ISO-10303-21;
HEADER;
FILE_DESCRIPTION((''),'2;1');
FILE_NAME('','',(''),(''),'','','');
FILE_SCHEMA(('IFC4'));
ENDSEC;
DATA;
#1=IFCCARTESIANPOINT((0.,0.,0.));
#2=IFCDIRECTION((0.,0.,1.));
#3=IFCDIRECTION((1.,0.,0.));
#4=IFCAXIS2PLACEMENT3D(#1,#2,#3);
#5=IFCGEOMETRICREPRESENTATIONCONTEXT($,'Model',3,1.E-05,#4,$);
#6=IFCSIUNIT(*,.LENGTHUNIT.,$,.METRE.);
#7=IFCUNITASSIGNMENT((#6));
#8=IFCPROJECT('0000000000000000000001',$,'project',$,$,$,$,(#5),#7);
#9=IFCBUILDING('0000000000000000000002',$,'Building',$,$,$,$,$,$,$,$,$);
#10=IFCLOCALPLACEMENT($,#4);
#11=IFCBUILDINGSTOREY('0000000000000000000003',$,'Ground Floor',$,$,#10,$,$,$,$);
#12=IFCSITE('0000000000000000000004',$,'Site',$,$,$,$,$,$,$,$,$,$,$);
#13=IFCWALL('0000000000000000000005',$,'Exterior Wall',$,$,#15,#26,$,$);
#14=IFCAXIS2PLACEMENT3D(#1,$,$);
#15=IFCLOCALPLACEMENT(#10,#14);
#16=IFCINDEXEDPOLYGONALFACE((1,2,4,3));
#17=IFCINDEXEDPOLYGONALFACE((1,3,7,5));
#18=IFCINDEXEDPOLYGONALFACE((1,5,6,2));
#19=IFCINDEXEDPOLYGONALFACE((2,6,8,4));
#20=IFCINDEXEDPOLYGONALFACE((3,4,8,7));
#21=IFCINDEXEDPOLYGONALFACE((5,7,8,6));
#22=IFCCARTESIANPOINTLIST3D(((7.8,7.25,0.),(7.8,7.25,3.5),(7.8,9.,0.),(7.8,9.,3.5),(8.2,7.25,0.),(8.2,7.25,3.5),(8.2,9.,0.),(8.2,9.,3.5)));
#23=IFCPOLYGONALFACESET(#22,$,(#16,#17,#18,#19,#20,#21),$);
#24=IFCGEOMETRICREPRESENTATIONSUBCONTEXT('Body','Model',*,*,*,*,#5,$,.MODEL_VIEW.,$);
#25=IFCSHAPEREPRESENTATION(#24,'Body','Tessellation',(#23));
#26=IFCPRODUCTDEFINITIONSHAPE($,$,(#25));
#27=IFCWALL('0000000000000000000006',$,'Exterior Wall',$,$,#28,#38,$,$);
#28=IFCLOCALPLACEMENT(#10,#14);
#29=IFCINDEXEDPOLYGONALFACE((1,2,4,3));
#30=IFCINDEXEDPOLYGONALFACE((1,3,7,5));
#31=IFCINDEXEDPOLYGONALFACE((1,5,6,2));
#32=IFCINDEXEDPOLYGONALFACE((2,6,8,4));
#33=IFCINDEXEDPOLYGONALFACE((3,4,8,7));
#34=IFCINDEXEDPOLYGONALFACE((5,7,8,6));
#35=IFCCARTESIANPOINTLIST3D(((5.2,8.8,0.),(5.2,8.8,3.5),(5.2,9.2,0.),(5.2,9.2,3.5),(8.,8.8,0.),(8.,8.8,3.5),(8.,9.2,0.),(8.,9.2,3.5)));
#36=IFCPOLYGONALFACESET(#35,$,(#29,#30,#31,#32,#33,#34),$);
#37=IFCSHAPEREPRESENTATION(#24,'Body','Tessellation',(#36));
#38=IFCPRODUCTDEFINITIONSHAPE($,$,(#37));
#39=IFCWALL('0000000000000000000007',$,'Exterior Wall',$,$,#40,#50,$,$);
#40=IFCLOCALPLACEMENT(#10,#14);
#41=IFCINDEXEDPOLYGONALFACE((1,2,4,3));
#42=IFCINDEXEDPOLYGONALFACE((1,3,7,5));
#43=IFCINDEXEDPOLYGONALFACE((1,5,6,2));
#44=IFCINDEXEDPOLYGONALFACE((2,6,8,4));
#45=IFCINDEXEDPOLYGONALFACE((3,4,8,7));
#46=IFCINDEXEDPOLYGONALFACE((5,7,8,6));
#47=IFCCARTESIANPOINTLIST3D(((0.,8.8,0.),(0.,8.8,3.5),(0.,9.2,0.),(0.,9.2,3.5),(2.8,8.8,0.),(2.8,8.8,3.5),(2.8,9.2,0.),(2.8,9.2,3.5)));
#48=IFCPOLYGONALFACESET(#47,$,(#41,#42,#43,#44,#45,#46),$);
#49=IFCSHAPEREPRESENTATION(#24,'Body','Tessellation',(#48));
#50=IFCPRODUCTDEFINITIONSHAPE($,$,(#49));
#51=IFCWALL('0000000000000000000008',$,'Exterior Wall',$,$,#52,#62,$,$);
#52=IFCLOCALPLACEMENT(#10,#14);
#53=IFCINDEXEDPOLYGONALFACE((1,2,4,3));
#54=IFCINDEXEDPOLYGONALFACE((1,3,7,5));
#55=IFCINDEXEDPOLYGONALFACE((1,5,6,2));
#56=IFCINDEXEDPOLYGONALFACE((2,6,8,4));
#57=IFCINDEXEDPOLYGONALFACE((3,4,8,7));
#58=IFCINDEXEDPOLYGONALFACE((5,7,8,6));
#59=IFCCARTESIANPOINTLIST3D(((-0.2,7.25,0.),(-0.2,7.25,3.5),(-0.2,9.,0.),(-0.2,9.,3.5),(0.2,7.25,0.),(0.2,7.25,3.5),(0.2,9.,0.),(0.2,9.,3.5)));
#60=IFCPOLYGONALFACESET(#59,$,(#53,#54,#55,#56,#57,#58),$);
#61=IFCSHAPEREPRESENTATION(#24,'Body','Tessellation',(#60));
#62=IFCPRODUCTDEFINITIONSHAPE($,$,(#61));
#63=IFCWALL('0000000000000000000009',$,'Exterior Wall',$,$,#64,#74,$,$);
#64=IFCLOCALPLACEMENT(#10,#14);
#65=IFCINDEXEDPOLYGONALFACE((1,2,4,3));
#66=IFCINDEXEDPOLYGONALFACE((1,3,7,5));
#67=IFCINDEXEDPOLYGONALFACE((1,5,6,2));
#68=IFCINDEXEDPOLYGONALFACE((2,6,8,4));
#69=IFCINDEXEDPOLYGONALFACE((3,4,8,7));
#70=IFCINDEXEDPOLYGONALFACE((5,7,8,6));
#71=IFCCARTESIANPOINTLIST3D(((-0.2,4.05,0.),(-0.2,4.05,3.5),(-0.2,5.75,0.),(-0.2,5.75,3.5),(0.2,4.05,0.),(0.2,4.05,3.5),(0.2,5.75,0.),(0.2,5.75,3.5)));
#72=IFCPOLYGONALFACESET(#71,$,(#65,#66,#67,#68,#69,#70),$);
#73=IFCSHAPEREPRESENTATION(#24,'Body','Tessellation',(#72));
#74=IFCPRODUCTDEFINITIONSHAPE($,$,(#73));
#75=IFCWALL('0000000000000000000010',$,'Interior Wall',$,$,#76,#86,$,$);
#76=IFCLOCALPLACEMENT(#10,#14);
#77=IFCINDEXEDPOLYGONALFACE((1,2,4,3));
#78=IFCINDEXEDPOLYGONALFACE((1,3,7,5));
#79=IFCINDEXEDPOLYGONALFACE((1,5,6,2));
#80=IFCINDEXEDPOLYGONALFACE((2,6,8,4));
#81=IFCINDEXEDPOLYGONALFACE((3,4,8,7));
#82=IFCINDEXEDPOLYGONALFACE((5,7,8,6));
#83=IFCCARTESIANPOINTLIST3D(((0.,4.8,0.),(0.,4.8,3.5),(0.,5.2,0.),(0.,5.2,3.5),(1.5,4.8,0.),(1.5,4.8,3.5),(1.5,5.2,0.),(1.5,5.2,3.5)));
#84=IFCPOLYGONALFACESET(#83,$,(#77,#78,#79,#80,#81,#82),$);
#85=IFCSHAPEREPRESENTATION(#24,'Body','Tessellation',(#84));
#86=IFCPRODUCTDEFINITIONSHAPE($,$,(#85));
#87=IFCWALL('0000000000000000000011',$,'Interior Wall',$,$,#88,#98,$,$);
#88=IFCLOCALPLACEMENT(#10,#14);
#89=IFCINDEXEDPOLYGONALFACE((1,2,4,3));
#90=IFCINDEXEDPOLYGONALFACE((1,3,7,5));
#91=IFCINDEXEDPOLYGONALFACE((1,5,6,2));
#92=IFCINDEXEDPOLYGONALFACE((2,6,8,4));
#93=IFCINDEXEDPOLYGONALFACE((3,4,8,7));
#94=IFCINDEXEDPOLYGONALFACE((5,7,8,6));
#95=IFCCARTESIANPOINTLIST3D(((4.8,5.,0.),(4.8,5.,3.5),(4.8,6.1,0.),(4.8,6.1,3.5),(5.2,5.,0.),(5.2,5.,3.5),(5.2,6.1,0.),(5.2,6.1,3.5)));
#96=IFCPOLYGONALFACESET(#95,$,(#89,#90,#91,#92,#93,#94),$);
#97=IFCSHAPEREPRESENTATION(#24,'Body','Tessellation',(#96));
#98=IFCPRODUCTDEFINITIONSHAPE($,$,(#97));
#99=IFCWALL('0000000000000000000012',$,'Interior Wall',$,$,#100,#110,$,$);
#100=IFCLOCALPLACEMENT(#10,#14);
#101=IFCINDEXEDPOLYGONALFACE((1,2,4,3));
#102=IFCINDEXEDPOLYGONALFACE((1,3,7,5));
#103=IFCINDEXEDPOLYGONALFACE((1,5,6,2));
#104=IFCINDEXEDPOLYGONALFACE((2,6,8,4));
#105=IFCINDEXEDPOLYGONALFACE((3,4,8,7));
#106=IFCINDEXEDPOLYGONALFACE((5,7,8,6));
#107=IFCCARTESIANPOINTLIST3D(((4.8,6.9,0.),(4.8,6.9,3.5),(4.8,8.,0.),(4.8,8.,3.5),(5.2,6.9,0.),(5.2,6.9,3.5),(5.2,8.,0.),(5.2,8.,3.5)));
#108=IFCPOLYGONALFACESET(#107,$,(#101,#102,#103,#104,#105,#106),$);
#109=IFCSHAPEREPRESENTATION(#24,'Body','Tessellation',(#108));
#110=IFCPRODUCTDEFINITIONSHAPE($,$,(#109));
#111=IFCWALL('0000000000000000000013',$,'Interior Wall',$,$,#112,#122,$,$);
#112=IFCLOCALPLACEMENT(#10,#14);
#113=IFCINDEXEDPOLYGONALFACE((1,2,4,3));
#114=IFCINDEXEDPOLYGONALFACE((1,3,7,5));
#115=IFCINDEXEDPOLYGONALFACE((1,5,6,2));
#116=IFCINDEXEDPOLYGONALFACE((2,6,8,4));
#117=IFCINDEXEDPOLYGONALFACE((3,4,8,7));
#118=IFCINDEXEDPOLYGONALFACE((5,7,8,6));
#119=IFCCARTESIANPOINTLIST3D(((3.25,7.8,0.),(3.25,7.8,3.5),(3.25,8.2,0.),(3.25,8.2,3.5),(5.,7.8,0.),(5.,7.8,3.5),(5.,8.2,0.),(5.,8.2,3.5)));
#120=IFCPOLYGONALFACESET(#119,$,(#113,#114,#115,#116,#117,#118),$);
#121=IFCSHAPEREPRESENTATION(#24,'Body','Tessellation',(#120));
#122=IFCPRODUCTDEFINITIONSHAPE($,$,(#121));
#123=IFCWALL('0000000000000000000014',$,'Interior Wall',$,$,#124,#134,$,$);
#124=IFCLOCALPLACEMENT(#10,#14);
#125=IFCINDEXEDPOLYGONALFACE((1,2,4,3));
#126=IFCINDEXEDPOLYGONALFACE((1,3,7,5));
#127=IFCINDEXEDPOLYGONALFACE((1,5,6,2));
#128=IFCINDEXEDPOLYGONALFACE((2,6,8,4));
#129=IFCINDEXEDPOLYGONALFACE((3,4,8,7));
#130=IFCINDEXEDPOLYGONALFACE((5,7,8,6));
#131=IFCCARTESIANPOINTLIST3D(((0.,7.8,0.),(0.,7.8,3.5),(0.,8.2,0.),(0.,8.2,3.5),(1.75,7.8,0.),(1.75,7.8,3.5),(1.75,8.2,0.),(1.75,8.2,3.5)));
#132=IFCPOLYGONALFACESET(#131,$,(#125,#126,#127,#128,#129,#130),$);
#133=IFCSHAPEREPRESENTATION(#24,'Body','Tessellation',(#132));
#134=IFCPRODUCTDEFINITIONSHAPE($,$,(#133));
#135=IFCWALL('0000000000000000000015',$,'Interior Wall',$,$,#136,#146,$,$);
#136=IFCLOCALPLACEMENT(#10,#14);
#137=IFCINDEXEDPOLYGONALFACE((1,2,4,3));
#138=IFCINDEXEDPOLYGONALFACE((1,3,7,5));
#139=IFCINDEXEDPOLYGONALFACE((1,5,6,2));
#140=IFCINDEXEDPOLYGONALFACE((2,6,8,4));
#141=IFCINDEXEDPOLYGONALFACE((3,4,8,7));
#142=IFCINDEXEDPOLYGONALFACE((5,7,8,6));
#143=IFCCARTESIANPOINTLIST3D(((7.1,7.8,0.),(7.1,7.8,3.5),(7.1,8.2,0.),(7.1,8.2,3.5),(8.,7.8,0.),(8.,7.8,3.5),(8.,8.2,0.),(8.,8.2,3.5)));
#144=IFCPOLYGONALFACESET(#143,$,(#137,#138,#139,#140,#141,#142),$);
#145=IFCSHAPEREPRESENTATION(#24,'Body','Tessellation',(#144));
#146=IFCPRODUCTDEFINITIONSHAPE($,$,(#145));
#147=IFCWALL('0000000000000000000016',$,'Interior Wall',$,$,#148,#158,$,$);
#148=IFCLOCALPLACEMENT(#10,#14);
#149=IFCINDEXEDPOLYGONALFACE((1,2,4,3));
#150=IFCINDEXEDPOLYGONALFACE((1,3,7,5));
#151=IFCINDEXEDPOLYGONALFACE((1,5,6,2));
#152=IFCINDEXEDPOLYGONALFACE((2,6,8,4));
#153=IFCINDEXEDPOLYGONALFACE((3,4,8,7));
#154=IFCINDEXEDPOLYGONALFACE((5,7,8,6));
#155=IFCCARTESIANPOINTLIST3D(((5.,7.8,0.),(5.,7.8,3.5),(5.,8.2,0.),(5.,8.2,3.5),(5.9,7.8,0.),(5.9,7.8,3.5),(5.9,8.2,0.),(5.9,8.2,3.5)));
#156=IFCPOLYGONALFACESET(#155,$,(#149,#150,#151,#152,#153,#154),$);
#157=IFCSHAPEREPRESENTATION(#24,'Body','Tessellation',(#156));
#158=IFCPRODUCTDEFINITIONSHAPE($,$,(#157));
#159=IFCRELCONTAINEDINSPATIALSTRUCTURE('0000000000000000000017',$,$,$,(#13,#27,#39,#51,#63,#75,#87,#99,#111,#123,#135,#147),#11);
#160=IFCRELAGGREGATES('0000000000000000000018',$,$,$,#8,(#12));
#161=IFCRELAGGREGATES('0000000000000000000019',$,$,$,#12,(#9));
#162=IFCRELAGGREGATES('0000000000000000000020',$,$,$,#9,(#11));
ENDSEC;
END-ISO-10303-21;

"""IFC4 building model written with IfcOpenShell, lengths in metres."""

from ifc_helpers import new_model, si_unit, frame, origin_with_axes, place, context, subcontext, project, spatial, indexed_curve, outline, extrude, element, save


model = new_model("IFC4")

# Units and contexts
model_context = context("Model", 3, precision=1e-05, world=origin_with_axes())
body_context = subcontext(model_context, "Body", "Model", "MODEL_VIEW")
ifc_project = project(units=[si_unit("LENGTHUNIT", "METRE")], contexts=[model_context])

# Site, building, storey
site = spatial("IfcSite", under=ifc_project, Name="Site")
building = spatial("IfcBuilding", under=site, Name="Building")
storey_placement = place(None, origin_with_axes())
storey = spatial("IfcBuildingStorey", under=building, at=storey_placement, Name="Ground Floor")

# Walls
wall_1_placement = place(storey_placement, frame((8.0, 7.25, 0.0), z_axis=(0.0, 0.0, 1.0), x_axis=(0.0, 1.0, 0.0)))
element("IfcWall", 1, at=wall_1_placement, inside=storey, Name="Exterior Wall", context=body_context, shape_type="SweptSolid", body=[
    extrude(outline(indexed_curve([(0.0, 0.0), (0.0, 0.4), (1.75, 0.4), (1.75, 0.0), (0.0, 0.0)], self_intersect=False)), frame((0.0, -0.2, 0.0), z_axis=(0.0, 0.0, 1.0), x_axis=(1.0, 0.0, 0.0)), (0.0, 0.0, 1.0), 3.5),
])
for number, where, z_axis, x_axis, name in (
    (2, (8.0, 9.0, 0.0), (0.0, 0.0, 1.0), (-1.0, 0.0, 0.0), "Exterior Wall"),
    (3, (2.8, 9.0, 0.0), (0.0, 0.0, 1.0), (-1.0, 0.0, 0.0), "Exterior Wall"),
):
    element("IfcWall", number, at=place(storey_placement, frame(where, z_axis=z_axis, x_axis=x_axis)), inside=storey, Name=name, context=body_context, shape_type="SweptSolid", body=[
        extrude(outline(indexed_curve([(0.0, 0.0), (0.0, 0.4), (2.8, 0.4), (2.8, 0.0), (0.0, 0.0)], self_intersect=False)), frame((0.0, -0.2, 0.0), z_axis=(0.0, 0.0, 1.0), x_axis=(1.0, 0.0, 0.0)), (0.0, 0.0, 1.0), 3.5),
    ])
wall_2_placement = place(storey_placement, frame((0.0, 9.0, 0.0), z_axis=(0.0, 0.0, 1.0), x_axis=(0.0, -1.0, 0.0)))
element("IfcWall", 4, at=wall_2_placement, inside=storey, Name="Exterior Wall", context=body_context, shape_type="SweptSolid", body=[
    extrude(outline(indexed_curve([(0.0, 0.0), (0.0, 0.4), (1.75, 0.4), (1.75, 0.0), (0.0, 0.0)], self_intersect=False)), frame((0.0, -0.2, 0.0), z_axis=(0.0, 0.0, 1.0), x_axis=(1.0, 0.0, 0.0)), (0.0, 0.0, 1.0), 3.5),
])
wall_3_placement = place(storey_placement, frame((0.0, 5.75, 0.0), z_axis=(0.0, 0.0, 1.0), x_axis=(0.0, -1.0, 0.0)))
element("IfcWall", 5, at=wall_3_placement, inside=storey, Name="Exterior Wall", context=body_context, shape_type="SweptSolid", body=[
    extrude(outline(indexed_curve([(0.0, 0.0), (0.0, 0.4), (1.7, 0.4), (1.7, 0.0), (0.0, 0.0)], self_intersect=False)), frame((0.0, -0.2, 0.0), z_axis=(0.0, 0.0, 1.0), x_axis=(1.0, 0.0, 0.0)), (0.0, 0.0, 1.0), 3.5),
])
wall_4_placement = place(storey_placement, frame((1.5, 5.0, 0.0), z_axis=(0.0, 0.0, 1.0), x_axis=(-1.0, 0.0, 0.0)))
element("IfcWall", 6, at=wall_4_placement, inside=storey, Name="Interior Wall", context=body_context, shape_type="SweptSolid", body=[
    extrude(outline(indexed_curve([(0.0, 0.0), (0.0, 0.4), (1.5, 0.4), (1.5, 0.0), (0.0, 0.0)], self_intersect=False)), frame((0.0, -0.2, 0.0), z_axis=(0.0, 0.0, 1.0), x_axis=(1.0, 0.0, 0.0)), (0.0, 0.0, 1.0), 3.5),
])
for number, where, z_axis, x_axis, name in (
    (7, (5.0, 5.0, 0.0), (0.0, 0.0, 1.0), (0.0, 1.0, 0.0), "Interior Wall"),
    (8, (5.0, 6.9, 0.0), (0.0, 0.0, 1.0), (0.0, 1.0, 0.0), "Interior Wall"),
):
    element("IfcWall", number, at=place(storey_placement, frame(where, z_axis=z_axis, x_axis=x_axis)), inside=storey, Name=name, context=body_context, shape_type="SweptSolid", body=[
        extrude(outline(indexed_curve([(0.0, 0.0), (0.0, 0.4), (1.1, 0.4), (1.1, 0.0), (0.0, 0.0)], self_intersect=False)), frame((0.0, -0.2, 0.0), z_axis=(0.0, 0.0, 1.0), x_axis=(1.0, 0.0, 0.0)), (0.0, 0.0, 1.0), 3.5),
    ])
for number, where, z_axis, x_axis, name in (
    (9, (5.0, 8.0, 0.0), (0.0, 0.0, 1.0), (-1.0, 0.0, 0.0), "Interior Wall"),
    (10, (1.75, 8.0, 0.0), (0.0, 0.0, 1.0), (-1.0, 0.0, 0.0), "Interior Wall"),
):
    element("IfcWall", number, at=place(storey_placement, frame(where, z_axis=z_axis, x_axis=x_axis)), inside=storey, Name=name, context=body_context, shape_type="SweptSolid", body=[
        extrude(outline(indexed_curve([(0.0, 0.0), (0.0, 0.4), (1.75, 0.4), (1.75, 0.0), (0.0, 0.0)], self_intersect=False)), frame((0.0, -0.2, 0.0), z_axis=(0.0, 0.0, 1.0), x_axis=(1.0, 0.0, 0.0)), (0.0, 0.0, 1.0), 3.5),
    ])
for number, where, z_axis, x_axis, name in (
    (11, (8.0, 8.0, 0.0), (0.0, 0.0, 1.0), (-1.0, 0.0, 0.0), "Interior Wall"),
    (12, (5.9, 8.0, 0.0), (0.0, 0.0, 1.0), (-1.0, 0.0, 0.0), "Interior Wall"),
):
    element("IfcWall", number, at=place(storey_placement, frame(where, z_axis=z_axis, x_axis=x_axis)), inside=storey, Name=name, context=body_context, shape_type="SweptSolid", body=[
        extrude(outline(indexed_curve([(0.0, 0.0), (0.0, 0.4), (0.9, 0.4), (0.9, 0.0), (0.0, 0.0)], self_intersect=False)), frame((0.0, -0.2, 0.0), z_axis=(0.0, 0.0, 1.0), x_axis=(1.0, 0.0, 0.0)), (0.0, 0.0, 1.0), 3.5),
    ])

save(model, "model.ifc")
